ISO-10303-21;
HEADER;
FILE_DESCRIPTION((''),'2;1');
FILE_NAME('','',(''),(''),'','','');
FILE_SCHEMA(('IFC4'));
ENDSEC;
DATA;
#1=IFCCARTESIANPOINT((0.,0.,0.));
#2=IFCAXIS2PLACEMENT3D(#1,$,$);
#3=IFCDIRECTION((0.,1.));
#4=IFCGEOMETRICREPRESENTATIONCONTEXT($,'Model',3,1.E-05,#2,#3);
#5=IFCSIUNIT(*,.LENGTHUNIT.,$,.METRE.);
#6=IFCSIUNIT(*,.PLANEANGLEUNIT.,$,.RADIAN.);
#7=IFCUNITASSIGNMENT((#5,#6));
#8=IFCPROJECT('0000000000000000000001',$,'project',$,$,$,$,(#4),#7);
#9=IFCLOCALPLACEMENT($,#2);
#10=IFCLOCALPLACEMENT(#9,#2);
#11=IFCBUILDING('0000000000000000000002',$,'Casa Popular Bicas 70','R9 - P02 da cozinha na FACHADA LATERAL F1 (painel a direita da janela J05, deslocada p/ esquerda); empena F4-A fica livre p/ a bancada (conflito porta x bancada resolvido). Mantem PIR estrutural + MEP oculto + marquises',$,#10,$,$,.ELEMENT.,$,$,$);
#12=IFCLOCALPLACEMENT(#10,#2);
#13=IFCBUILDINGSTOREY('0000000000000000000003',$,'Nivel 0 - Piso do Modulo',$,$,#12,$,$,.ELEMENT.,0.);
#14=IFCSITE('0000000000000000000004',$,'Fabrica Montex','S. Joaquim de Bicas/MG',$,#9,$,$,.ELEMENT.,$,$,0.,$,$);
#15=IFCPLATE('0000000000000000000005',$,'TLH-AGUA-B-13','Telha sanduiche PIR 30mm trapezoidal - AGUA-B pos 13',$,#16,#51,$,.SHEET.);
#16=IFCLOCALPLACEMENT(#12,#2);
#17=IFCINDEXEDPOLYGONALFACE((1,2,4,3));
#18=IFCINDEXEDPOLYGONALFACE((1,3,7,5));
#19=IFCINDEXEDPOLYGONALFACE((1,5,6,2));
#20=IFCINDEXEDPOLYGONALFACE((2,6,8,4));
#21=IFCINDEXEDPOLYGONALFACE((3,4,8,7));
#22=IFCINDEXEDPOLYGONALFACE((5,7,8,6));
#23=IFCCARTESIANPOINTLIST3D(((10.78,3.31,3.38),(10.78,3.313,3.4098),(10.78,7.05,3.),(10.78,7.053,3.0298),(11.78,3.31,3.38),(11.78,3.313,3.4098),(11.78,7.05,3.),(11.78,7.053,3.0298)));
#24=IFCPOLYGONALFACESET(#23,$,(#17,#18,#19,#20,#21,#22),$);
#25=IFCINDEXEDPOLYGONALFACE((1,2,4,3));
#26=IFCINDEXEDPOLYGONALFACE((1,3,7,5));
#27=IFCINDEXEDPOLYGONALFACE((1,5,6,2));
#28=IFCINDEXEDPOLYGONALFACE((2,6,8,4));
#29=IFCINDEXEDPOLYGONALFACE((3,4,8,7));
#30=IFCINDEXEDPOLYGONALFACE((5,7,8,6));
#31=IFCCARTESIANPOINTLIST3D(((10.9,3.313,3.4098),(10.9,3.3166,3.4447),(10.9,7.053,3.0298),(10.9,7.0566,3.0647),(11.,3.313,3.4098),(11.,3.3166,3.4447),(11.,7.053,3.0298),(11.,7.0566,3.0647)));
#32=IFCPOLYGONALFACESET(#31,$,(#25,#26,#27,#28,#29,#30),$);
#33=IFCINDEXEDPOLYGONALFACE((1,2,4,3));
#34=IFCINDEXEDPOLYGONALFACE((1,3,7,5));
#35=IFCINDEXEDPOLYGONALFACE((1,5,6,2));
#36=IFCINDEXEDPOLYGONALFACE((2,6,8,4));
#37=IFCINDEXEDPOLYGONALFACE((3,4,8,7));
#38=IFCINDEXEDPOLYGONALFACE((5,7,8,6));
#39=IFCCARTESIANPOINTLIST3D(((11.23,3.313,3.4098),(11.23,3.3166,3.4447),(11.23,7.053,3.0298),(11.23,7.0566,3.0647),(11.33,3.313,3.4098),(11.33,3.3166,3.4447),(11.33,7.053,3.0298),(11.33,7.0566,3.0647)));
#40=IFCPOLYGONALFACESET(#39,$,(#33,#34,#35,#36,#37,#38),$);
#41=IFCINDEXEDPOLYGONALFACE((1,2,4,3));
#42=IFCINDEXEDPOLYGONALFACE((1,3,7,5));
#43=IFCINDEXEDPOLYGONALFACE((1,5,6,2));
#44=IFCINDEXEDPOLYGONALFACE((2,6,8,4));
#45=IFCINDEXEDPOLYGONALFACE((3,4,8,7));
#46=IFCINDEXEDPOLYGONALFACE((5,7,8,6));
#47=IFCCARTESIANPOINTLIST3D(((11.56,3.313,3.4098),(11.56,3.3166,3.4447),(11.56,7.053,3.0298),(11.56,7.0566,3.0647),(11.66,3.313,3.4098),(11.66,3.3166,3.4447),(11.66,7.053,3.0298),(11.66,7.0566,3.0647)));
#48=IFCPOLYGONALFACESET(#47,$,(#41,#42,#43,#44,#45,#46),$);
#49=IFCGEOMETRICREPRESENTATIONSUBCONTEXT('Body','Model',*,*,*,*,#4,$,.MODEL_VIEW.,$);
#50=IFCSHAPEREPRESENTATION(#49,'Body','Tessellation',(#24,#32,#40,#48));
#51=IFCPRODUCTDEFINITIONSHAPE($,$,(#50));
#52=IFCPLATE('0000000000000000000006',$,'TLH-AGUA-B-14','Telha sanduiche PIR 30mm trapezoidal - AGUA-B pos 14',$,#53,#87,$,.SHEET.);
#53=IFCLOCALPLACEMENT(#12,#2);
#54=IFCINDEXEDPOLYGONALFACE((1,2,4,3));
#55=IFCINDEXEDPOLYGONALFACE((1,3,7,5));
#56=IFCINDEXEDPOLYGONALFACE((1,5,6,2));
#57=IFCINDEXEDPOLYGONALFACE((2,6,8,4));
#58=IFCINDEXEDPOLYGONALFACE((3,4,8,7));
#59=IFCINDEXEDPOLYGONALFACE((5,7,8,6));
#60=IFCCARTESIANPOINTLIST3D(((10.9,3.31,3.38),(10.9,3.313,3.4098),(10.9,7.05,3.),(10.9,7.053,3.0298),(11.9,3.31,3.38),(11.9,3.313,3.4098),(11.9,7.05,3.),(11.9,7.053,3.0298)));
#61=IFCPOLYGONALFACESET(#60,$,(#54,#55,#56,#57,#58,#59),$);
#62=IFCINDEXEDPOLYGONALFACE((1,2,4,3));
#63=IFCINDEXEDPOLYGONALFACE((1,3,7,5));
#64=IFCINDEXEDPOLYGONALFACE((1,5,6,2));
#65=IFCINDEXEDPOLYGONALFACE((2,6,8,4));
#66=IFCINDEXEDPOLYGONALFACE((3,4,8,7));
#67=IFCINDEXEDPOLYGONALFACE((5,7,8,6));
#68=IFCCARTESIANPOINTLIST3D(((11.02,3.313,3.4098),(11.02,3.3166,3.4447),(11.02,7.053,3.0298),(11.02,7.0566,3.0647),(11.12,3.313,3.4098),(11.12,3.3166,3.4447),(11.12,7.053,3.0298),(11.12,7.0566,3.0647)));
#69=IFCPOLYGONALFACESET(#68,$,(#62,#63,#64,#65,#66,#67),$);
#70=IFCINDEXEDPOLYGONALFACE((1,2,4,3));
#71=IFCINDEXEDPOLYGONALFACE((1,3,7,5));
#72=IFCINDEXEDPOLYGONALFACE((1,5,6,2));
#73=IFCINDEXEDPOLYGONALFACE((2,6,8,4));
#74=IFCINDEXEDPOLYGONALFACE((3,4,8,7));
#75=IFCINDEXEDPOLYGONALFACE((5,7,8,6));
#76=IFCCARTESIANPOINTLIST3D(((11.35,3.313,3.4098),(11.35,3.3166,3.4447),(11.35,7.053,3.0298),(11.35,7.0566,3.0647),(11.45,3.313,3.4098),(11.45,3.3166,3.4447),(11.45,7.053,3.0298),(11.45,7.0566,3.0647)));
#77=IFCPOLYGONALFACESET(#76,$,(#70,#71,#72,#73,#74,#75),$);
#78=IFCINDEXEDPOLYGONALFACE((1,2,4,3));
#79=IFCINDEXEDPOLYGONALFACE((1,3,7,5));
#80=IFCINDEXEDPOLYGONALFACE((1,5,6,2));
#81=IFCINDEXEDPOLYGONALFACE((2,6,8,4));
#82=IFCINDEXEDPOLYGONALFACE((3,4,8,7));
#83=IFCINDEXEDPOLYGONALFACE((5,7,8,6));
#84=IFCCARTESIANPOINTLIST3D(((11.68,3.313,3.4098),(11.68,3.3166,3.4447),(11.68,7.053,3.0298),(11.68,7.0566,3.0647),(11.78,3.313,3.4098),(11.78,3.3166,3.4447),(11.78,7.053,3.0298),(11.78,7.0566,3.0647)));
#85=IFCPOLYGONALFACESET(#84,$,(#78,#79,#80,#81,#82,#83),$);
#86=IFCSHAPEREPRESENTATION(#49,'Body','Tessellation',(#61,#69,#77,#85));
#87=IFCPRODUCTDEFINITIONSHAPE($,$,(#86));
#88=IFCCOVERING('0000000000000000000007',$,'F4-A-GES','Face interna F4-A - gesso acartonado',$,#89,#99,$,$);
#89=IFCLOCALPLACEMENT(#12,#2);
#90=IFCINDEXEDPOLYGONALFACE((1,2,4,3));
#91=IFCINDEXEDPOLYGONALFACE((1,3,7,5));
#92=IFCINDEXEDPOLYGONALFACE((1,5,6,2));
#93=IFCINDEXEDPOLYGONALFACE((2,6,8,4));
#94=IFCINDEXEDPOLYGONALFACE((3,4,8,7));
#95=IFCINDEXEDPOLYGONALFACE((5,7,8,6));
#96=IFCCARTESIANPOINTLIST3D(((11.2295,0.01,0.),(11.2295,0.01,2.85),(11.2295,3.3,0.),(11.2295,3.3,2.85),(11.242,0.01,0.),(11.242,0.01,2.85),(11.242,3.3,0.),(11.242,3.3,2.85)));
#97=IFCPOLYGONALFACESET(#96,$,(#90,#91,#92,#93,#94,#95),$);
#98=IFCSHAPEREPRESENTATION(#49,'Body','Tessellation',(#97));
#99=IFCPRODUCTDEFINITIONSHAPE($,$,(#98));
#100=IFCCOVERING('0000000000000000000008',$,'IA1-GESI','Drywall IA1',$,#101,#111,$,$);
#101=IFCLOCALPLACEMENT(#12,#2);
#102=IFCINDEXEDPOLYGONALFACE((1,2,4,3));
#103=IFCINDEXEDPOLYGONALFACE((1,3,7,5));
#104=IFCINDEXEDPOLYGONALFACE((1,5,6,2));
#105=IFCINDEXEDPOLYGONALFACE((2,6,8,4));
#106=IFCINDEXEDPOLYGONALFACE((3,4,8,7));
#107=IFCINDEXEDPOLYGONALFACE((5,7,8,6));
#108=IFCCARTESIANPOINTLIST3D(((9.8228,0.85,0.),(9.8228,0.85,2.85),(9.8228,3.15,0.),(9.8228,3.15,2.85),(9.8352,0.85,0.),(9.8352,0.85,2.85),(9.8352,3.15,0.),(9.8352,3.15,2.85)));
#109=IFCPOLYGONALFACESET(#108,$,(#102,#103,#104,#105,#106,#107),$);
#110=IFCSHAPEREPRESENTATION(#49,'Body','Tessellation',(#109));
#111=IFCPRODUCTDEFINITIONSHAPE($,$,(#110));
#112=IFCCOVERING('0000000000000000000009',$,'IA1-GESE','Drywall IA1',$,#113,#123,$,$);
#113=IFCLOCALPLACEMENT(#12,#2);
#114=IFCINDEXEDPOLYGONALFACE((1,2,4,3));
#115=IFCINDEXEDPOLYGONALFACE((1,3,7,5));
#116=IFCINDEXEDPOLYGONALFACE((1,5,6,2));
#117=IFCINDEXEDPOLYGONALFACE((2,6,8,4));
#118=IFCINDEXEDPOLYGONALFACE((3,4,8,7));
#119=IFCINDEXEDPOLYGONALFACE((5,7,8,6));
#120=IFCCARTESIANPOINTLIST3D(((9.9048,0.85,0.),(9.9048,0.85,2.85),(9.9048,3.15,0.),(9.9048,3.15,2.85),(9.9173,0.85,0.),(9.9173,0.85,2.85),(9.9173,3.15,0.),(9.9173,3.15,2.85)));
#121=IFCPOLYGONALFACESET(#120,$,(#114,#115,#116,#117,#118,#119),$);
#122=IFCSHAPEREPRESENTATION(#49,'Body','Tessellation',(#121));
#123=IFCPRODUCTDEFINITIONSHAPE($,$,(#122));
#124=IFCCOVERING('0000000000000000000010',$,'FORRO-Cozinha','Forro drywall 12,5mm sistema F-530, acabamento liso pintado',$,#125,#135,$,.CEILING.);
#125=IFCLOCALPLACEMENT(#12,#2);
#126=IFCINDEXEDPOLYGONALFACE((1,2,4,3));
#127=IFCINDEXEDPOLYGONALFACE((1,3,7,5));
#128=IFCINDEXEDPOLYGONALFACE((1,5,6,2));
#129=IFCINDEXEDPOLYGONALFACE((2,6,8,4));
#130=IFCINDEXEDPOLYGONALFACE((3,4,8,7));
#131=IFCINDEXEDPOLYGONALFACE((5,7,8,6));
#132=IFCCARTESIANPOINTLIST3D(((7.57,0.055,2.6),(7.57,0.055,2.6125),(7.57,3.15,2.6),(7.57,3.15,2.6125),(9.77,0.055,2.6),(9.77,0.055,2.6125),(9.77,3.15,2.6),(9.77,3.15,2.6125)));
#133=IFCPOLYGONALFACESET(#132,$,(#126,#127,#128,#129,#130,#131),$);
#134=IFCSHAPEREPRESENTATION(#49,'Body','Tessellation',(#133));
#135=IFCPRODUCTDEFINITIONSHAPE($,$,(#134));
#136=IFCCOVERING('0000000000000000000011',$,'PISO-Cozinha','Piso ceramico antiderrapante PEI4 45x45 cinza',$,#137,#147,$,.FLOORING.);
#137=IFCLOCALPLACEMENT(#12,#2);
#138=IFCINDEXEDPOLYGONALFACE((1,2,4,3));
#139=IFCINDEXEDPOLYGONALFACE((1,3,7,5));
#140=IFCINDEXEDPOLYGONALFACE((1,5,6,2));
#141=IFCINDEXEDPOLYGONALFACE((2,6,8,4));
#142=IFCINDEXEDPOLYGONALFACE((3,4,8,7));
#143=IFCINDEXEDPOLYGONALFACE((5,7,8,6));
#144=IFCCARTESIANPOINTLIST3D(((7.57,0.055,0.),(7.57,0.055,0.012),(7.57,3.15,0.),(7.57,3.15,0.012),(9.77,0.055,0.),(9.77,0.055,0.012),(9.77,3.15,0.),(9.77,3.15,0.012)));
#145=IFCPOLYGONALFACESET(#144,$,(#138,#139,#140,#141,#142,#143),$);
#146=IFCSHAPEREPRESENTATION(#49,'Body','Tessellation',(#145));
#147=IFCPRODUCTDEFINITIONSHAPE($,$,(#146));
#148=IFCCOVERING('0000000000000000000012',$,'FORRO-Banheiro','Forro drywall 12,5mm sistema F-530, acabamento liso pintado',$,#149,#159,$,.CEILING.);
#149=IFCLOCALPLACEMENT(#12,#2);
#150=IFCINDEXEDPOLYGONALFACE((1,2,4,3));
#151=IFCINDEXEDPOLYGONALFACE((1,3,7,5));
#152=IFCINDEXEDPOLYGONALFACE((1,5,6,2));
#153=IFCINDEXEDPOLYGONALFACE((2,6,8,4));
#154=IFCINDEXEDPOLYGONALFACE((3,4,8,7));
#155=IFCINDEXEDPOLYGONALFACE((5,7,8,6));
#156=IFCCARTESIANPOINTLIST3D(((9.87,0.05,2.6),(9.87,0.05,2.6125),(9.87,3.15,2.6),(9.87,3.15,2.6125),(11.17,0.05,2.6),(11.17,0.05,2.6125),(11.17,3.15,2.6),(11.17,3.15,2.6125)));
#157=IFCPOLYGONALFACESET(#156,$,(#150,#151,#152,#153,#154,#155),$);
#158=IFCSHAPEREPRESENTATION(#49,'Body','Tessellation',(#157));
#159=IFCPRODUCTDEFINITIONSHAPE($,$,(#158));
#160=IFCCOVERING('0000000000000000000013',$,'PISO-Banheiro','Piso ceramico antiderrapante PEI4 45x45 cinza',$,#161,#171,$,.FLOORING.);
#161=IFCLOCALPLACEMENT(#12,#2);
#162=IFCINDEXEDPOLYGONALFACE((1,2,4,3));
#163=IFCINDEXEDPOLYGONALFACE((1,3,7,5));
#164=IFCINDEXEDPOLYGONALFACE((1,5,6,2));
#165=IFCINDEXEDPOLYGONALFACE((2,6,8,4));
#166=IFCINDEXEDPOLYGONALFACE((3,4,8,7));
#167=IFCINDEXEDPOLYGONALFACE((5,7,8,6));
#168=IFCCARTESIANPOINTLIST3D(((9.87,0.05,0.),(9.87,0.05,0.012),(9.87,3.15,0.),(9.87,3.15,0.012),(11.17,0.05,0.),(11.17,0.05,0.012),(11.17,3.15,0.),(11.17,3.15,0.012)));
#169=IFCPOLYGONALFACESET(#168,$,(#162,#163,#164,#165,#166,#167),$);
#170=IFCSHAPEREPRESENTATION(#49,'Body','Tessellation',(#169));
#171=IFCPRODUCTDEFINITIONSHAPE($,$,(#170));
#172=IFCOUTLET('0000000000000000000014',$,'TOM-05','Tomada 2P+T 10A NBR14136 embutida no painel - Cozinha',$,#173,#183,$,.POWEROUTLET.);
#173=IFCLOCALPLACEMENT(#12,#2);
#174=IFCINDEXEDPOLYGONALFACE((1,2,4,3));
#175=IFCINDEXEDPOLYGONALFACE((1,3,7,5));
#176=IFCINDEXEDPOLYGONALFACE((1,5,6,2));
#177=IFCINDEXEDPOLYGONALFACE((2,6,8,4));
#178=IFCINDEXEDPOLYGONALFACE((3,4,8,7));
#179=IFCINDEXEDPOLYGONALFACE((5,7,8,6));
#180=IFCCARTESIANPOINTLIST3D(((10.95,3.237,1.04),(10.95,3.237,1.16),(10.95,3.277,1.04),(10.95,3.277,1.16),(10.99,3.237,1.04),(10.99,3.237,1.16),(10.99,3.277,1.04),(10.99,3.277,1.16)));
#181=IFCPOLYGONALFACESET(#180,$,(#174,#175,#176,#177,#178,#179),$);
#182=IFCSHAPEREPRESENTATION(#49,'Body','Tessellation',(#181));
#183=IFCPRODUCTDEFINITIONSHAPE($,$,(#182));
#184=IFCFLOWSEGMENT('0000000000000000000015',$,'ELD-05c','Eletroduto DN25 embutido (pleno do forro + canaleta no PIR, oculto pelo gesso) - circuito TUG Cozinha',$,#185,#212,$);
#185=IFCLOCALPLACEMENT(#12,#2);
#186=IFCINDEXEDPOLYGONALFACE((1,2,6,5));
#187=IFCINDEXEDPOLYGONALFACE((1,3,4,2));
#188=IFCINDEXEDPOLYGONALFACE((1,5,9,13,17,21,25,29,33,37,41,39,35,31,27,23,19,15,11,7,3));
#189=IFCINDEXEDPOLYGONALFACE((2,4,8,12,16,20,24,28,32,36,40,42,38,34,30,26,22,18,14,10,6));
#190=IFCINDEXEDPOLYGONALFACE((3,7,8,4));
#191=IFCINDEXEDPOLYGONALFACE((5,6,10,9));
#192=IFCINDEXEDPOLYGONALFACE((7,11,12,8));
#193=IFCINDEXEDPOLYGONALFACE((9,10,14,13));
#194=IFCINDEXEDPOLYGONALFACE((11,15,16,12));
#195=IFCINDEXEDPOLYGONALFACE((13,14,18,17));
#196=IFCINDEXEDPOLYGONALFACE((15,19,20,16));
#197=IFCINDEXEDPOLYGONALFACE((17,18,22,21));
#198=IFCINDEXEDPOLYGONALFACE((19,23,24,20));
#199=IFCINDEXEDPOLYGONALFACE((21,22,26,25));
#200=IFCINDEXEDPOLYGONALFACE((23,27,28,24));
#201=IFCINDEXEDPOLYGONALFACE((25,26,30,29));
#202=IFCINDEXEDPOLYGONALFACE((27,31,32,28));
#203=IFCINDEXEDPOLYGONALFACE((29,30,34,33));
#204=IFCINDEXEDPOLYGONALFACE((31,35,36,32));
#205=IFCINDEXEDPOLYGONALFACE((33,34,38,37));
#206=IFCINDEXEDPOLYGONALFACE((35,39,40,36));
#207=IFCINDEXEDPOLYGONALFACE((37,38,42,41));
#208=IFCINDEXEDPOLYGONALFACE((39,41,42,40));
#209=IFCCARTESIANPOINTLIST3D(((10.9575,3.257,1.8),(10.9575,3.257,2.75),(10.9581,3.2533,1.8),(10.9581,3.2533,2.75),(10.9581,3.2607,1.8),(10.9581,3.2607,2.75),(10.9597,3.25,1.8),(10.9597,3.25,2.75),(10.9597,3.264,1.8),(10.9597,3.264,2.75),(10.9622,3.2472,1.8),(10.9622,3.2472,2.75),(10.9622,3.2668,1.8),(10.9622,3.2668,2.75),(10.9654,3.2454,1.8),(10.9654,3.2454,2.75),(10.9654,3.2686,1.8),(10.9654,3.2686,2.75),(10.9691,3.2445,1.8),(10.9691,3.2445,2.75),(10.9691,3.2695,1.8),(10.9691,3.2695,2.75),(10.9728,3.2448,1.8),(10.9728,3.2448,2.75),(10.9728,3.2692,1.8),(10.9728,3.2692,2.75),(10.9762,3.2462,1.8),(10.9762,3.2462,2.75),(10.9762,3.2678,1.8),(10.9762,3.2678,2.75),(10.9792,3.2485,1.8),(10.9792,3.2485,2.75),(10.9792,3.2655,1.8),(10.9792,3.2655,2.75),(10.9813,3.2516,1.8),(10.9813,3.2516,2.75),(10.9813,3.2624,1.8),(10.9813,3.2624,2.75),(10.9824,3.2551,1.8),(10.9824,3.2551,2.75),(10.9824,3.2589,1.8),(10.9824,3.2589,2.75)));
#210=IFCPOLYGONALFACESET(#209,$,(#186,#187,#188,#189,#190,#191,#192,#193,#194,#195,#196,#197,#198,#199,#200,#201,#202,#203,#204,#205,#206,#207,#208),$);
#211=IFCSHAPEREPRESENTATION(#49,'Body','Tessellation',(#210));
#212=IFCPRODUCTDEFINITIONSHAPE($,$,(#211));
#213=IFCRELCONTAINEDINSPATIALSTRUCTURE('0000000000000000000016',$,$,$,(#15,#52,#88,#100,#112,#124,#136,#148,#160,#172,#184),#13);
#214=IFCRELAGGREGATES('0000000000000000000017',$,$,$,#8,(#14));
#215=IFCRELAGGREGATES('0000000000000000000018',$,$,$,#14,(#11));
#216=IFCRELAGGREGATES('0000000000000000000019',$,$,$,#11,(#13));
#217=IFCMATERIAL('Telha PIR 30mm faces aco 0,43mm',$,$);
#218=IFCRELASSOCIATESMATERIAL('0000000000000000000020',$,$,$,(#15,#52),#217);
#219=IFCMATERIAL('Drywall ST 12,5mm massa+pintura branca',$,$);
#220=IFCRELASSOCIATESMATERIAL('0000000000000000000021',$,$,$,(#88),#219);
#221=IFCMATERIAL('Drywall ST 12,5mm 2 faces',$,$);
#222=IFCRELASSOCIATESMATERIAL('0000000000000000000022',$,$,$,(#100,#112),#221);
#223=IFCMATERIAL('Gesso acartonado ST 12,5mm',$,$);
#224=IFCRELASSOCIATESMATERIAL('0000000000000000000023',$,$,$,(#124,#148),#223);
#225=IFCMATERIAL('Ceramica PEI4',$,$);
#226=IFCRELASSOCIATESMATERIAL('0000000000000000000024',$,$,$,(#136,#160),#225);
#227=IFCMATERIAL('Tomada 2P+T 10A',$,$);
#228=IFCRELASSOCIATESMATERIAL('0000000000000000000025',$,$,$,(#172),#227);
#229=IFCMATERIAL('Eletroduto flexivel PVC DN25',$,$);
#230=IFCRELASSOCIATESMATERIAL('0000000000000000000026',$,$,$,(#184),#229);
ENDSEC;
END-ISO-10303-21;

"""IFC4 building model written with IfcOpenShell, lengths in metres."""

from ifc_helpers import new_model, si_unit, direction, frame, frame_2d, origin, origin_2d, place, context, subcontext, project, spatial, rectangle, circle, extrude, material, element, save


model = new_model("IFC4")

# Units and contexts
model_context = context("Model", 3, precision=1e-05, world=origin(), true_north=direction((0.0, 1.0)))
body_context = subcontext(model_context, "Body", "Model", "MODEL_VIEW")
ifc_project = project(units=[si_unit("LENGTHUNIT", "METRE"), si_unit("PLANEANGLEUNIT", "RADIAN")], contexts=[model_context])

# Site, building, storey
site_placement = place(None, origin())
site = spatial("IfcSite", under=ifc_project, at=site_placement, Name="Fabrica Montex", Description="S. Joaquim de Bicas/MG", CompositionType="ELEMENT", RefElevation=0.0)
building_placement = place(site_placement, origin())
building = spatial("IfcBuilding", under=site, at=building_placement, Name="Casa Popular Bicas 70", Description="R9 - P02 da cozinha na FACHADA LATERAL F1 (painel a direita da janela J05, deslocada p/ esquerda); empena F4-A fica livre p/ a bancada (conflito porta x bancada resolvido). Mantem PIR estrutural + MEP oculto + marquises", CompositionType="ELEMENT")
storey_placement = place(building_placement, origin())
storey = spatial("IfcBuildingStorey", under=building, at=storey_placement, Name="Nivel 0 - Piso do Modulo", CompositionType="ELEMENT", Elevation=0.0)

# Plates
ifc_material_1 = material(Name="Telha PIR 30mm faces aco 0,43mm")
for number, where, z_axis, x_axis, name, description in (
    (1, (10.78, 3.31, 3.38), (0.0, 0.101084, 0.994878), (1.0, 0.0, 0.0), "TLH-AGUA-B-13", "Telha sanduiche PIR 30mm trapezoidal - AGUA-B pos 13"),
    (2, (10.9, 3.31, 3.38), (0.0, 0.101084, 0.994878), (1.0, 0.0, 0.0), "TLH-AGUA-B-14", "Telha sanduiche PIR 30mm trapezoidal - AGUA-B pos 14"),
):
    element("IfcPlate", number, at=place(storey_placement, frame(where, z_axis=z_axis, x_axis=x_axis)), inside=storey, material=ifc_material_1, Name=name, Description=description, PredefinedType="SHEET", context=body_context, shape_type="SweptSolid", body=[
        extrude(rectangle(XDim=1.0, YDim=3.7593, at=frame_2d((0.5, 1.8796))), origin(), (0.0, 0.0, 1.0), 0.03),
        extrude(rectangle(XDim=0.1, YDim=3.7593, at=frame_2d((0.17, 1.8796))), frame((0.0, 0.0, 0.03)), (0.0, 0.0, 1.0), 0.035),
        extrude(rectangle(XDim=0.1, YDim=3.7593, at=frame_2d((0.5, 1.8796))), frame((0.0, 0.0, 0.03)), (0.0, 0.0, 1.0), 0.035),
        extrude(rectangle(XDim=0.1, YDim=3.7593, at=frame_2d((0.83, 1.8796))), frame((0.0, 0.0, 0.03)), (0.0, 0.0, 1.0), 0.035),
    ])

# Coverings
ifc_material_2 = material(Name="Drywall ST 12,5mm massa+pintura branca")
covering_1_placement = place(None, frame((11.2357, 3.3, 0.0), z_axis=(0.0, 0.0, 1.0), x_axis=(0.0, -1.0, 0.0)))
element("IfcCovering", 3, at=covering_1_placement, inside=storey, material=ifc_material_2, Name="F4-A-GES", Description="Face interna F4-A - gesso acartonado", context=body_context, shape_type="SweptSolid", body=[
    extrude(rectangle(XDim=3.29, YDim=0.0125, at=frame_2d((1.645, 0.0))), origin(), (0.0, 0.0, 1.0), 2.85),
])
ifc_material_3 = material(Name="Drywall ST 12,5mm 2 faces")
for number, where, z_axis, x_axis, name in (
    (4, (9.829, 3.15, 0.0), (0.0, 0.0, 1.0), (0.0, -1.0, 0.0), "IA1-GESI"),
    (5, (9.911, 3.15, 0.0), (0.0, 0.0, 1.0), (0.0, -1.0, 0.0), "IA1-GESE"),
):
    element("IfcCovering", number, at=place(None, frame(where, z_axis=z_axis, x_axis=x_axis)), inside=storey, material=ifc_material_3, Name=name, Description="Drywall IA1", context=body_context, shape_type="SweptSolid", body=[
        extrude(rectangle(XDim=2.3, YDim=0.0125, at=frame_2d((1.15, 0.0))), origin(), (0.0, 0.0, 1.0), 2.85),
    ])
ifc_material_4 = material(Name="Gesso acartonado ST 12,5mm")
covering_2_placement = place(None, frame((9.77, 3.15, 2.6), z_axis=(0.0, 0.0, 1.0), x_axis=(-1.0, 0.0, 0.0)))
element("IfcCovering", 6, at=covering_2_placement, inside=storey, material=ifc_material_4, Name="FORRO-Cozinha", Description="Forro drywall 12,5mm sistema F-530, acabamento liso pintado", PredefinedType="CEILING", context=body_context, shape_type="SweptSolid", body=[
    extrude(rectangle(XDim=2.2, YDim=3.095, at=frame_2d((1.1, 1.5475))), origin(), (0.0, 0.0, 1.0), 0.0125),
])
ifc_material_5 = material(Name="Ceramica PEI4")
covering_3_placement = place(None, frame((9.77, 3.15, 0.0), z_axis=(0.0, 0.0, 1.0), x_axis=(-1.0, 0.0, 0.0)))
element("IfcCovering", 7, at=covering_3_placement, inside=storey, material=ifc_material_5, Name="PISO-Cozinha", Description="Piso ceramico antiderrapante PEI4 45x45 cinza", PredefinedType="FLOORING", context=body_context, shape_type="SweptSolid", body=[
    extrude(rectangle(XDim=2.2, YDim=3.095, at=frame_2d((1.1, 1.5475))), origin(), (0.0, 0.0, 1.0), 0.012),
])
covering_4_placement = place(None, frame((11.17, 3.15, 2.6), z_axis=(0.0, 0.0, 1.0), x_axis=(-1.0, 0.0, 0.0)))
element("IfcCovering", 8, at=covering_4_placement, inside=storey, material=ifc_material_4, Name="FORRO-Banheiro", Description="Forro drywall 12,5mm sistema F-530, acabamento liso pintado", PredefinedType="CEILING", context=body_context, shape_type="SweptSolid", body=[
    extrude(rectangle(XDim=1.3, YDim=3.1, at=frame_2d((0.65, 1.55))), origin(), (0.0, 0.0, 1.0), 0.0125),
])
covering_5_placement = place(None, frame((11.17, 3.15, 0.0), z_axis=(0.0, 0.0, 1.0), x_axis=(-1.0, 0.0, 0.0)))
element("IfcCovering", 9, at=covering_5_placement, inside=storey, material=ifc_material_5, Name="PISO-Banheiro", Description="Piso ceramico antiderrapante PEI4 45x45 cinza", PredefinedType="FLOORING", context=body_context, shape_type="SweptSolid", body=[
    extrude(rectangle(XDim=1.3, YDim=3.1, at=frame_2d((0.65, 1.55))), origin(), (0.0, 0.0, 1.0), 0.012),
])

# Outlet
ifc_material_6 = material(Name="Tomada 2P+T 10A")
outlet_1_placement = place(None, frame((10.99, 3.277, 1.04), z_axis=(0.0, 0.0, 1.0), x_axis=(-1.0, 0.0, 0.0)))
element("IfcOutlet", 10, at=outlet_1_placement, inside=storey, material=ifc_material_6, Name="TOM-05", Description="Tomada 2P+T 10A NBR14136 embutida no painel - Cozinha", PredefinedType="POWEROUTLET", context=body_context, shape_type="SweptSolid", body=[
    extrude(rectangle(XDim=0.04, YDim=0.04, at=frame_2d((0.02, 0.02))), origin(), (0.0, 0.0, 1.0), 0.12),
])

# Flow segment
ifc_material_7 = material(Name="Eletroduto flexivel PVC DN25")
flow_segment_1_placement = place(None, frame((10.97, 3.257, 2.75), z_axis=(0.0, 0.0, -1.0), x_axis=(-1.0, 0.0, 0.0)))
element("IfcFlowSegment", 11, at=flow_segment_1_placement, inside=storey, material=ifc_material_7, Name="ELD-05c", Description="Eletroduto DN25 embutido (pleno do forro + canaleta no PIR, oculto pelo gesso) - circuito TUG Cozinha", context=body_context, shape_type="SweptSolid", body=[
    extrude(circle(Radius=0.0125, at=origin_2d()), origin(), (0.0, 0.0, 1.0), 0.95),
])

save(model, "model.ifc")
